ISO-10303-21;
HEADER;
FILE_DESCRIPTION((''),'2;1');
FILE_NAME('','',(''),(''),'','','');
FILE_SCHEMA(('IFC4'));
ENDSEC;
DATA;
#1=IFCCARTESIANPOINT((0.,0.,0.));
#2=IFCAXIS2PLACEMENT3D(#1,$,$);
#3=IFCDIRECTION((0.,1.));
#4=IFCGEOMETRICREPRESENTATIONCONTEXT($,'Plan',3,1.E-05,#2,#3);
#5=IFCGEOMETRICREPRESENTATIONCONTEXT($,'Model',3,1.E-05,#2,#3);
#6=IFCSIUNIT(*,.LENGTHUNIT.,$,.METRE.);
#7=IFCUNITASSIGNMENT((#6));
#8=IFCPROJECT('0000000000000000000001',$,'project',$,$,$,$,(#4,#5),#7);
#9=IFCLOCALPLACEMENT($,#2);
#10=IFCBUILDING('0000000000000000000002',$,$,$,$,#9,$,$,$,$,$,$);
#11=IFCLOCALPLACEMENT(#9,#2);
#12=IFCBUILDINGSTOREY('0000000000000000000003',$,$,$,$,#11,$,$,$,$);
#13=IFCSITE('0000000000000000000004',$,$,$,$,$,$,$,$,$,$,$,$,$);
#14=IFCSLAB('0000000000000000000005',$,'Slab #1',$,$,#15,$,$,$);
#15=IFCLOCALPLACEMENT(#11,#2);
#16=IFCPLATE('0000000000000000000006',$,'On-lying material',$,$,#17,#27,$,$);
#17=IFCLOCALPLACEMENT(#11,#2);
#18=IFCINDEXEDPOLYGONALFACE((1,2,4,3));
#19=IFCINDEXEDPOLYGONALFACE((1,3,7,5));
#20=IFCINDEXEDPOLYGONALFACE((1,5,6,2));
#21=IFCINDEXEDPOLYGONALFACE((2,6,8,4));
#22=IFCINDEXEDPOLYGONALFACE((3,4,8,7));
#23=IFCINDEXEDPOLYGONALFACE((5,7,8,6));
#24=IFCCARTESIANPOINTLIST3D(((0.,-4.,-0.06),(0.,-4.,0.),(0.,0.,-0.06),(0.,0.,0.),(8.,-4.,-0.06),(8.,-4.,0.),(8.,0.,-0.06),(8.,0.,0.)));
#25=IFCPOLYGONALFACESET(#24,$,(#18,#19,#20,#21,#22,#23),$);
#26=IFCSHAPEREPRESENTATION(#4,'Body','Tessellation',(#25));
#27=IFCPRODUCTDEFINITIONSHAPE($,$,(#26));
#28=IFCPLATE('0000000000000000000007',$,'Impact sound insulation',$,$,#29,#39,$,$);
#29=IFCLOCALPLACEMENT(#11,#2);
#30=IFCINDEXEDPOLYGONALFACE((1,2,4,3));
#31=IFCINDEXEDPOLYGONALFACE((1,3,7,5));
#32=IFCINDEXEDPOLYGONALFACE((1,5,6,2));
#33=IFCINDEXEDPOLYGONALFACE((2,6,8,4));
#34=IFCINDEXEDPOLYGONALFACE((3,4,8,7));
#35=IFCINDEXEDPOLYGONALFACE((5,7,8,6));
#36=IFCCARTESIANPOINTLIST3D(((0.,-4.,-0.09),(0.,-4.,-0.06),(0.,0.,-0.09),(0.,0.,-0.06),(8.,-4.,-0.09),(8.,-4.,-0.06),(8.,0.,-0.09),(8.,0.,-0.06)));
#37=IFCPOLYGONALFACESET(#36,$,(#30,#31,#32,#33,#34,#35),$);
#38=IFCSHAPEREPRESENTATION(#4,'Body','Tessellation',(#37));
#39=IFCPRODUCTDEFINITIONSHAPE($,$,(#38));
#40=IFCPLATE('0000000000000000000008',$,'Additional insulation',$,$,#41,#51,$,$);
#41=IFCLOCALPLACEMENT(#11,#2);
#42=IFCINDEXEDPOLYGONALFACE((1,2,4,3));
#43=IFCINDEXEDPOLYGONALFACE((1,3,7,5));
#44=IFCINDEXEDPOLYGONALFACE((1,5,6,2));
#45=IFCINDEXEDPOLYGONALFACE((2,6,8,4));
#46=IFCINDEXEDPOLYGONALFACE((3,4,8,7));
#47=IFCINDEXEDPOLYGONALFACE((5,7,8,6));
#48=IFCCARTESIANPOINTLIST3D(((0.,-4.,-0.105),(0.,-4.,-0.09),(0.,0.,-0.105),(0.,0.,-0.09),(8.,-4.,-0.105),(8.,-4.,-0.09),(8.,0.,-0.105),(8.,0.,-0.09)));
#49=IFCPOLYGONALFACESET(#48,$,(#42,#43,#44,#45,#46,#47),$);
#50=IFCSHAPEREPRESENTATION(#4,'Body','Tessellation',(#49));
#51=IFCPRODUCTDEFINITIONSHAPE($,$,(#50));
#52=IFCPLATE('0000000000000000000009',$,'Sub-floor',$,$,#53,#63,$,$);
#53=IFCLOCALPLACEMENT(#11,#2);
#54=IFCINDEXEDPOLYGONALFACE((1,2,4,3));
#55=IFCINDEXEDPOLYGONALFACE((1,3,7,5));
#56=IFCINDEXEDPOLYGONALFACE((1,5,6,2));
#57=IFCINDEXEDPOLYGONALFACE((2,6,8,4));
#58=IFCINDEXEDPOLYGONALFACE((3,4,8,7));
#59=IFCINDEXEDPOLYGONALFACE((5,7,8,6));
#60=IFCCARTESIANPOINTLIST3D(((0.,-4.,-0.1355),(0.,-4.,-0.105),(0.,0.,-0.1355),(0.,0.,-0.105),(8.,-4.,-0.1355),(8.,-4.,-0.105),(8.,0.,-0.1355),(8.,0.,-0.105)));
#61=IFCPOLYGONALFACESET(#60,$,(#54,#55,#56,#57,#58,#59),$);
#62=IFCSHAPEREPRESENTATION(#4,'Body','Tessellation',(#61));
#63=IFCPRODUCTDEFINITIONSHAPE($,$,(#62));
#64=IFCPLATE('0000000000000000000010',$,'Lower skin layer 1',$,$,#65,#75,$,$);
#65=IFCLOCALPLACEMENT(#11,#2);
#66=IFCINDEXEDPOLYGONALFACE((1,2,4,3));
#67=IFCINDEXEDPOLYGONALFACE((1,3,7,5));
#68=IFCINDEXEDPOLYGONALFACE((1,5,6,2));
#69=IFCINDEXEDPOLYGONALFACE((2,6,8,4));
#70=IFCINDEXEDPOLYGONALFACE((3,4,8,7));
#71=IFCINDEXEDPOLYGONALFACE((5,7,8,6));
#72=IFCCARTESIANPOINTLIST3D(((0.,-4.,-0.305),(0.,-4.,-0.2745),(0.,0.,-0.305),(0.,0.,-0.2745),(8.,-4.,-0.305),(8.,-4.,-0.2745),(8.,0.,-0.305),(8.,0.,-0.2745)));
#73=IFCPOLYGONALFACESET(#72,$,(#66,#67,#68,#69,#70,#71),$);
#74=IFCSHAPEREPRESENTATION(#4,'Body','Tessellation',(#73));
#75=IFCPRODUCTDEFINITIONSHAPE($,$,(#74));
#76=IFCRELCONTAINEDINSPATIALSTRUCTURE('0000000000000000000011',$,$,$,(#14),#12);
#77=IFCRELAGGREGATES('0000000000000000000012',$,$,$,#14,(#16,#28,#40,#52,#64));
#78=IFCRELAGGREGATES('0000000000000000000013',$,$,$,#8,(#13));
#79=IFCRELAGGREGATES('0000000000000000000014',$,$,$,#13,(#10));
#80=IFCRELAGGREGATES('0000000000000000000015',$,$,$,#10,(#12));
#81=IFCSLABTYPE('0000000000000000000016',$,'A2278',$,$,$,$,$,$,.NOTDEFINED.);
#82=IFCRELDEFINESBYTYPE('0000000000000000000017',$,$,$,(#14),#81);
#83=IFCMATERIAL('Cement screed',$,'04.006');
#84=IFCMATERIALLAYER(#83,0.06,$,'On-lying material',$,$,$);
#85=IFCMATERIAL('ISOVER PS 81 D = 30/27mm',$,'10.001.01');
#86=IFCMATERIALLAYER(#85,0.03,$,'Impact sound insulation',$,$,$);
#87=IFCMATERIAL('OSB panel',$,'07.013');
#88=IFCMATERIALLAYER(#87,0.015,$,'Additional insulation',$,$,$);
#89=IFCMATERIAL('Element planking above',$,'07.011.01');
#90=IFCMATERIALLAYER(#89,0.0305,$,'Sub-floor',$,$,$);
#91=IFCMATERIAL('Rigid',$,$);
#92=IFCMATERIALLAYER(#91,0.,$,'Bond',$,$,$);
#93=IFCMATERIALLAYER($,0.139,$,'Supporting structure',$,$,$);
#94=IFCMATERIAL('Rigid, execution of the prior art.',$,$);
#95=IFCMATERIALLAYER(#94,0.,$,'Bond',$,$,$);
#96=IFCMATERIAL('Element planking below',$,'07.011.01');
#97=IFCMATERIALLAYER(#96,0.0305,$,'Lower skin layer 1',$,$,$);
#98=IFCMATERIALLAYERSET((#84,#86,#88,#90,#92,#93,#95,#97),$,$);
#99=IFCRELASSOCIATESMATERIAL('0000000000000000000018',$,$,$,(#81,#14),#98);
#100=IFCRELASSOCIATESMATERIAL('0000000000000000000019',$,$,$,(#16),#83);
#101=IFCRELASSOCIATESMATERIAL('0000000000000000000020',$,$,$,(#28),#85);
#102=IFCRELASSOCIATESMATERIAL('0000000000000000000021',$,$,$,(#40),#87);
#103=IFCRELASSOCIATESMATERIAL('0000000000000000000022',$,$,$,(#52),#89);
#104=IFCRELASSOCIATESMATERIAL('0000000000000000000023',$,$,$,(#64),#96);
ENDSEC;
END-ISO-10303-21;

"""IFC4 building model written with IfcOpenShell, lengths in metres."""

from ifc_helpers import new_model, si_unit, direction, frame, frame_2d, origin, origin_with_axes, place, context, project, spatial, rectangle, extrude, material, layer, layer_set, type_object, element, aggregate, save


model = new_model("IFC4")

# Units and contexts
plan_context = context("Plan", 3, precision=1e-05, world=origin(), true_north=direction((0.0, 1.0)))
model_context = context("Model", 3, precision=1e-05, world=origin(), true_north=direction((0.0, 1.0)))
ifc_project = project(units=[si_unit("LENGTHUNIT", "METRE")], contexts=[plan_context, model_context])

# Site, building, storey
site = spatial("IfcSite", under=ifc_project)
building_placement = place(None, origin())
building = spatial("IfcBuilding", under=site, at=building_placement)
storey_placement = place(building_placement, origin())
storey = spatial("IfcBuildingStorey", under=building, at=storey_placement)

# Slab, plates
ifc_material_1 = material(Name="Cement screed", Category="04.006")
ifc_layer_1 = layer(ifc_material_1, 0.06, Name="On-lying material")
ifc_material_2 = material(Name="ISOVER PS 81 D = 30/27mm", Category="10.001.01")
ifc_layer_2 = layer(ifc_material_2, 0.03, Name="Impact sound insulation")
ifc_material_3 = material(Name="OSB panel", Category="07.013")
ifc_layer_3 = layer(ifc_material_3, 0.015, Name="Additional insulation")
ifc_material_4 = material(Name="Element planking above", Category="07.011.01")
ifc_layer_4 = layer(ifc_material_4, 0.0305, Name="Sub-floor")
ifc_material_5 = material(Name="Rigid")
ifc_layer_5 = layer(ifc_material_5, 0.0, Name="Bond")
ifc_layer_6 = layer(None, 0.139, Name="Supporting structure")
ifc_material_6 = material(Name="Rigid, execution of the prior art.")
ifc_layer_7 = layer(ifc_material_6, 0.0, Name="Bond")
ifc_material_7 = material(Name="Element planking below", Category="07.011.01")
ifc_layer_8 = layer(ifc_material_7, 0.0305, Name="Lower skin layer 1")
ifc_layer_set = layer_set([ifc_layer_1, ifc_layer_2, ifc_layer_3, ifc_layer_4, ifc_layer_5, ifc_layer_6, ifc_layer_7, ifc_layer_8])
slab_type = type_object("IfcSlabType", Name="A2278", PredefinedType="NOTDEFINED", material=ifc_layer_set)
slab_placement = place(None, frame((0.0, 0.0, 0.0), z_axis=(0.0, 0.0, -1.0), x_axis=(1.0, 0.0, 0.0)))
slab = element("IfcSlab", 1, at=slab_placement, inside=storey, type_object=slab_type, material=ifc_layer_set, Name="Slab #1")
plate_1_placement = place(slab_placement, origin())
plate_1 = element("IfcPlate", 2, at=plate_1_placement, material=ifc_material_1, Name="On-lying material", context=plan_context, shape_type="SweptSolid", body=[
    extrude(rectangle(XDim=8.0, YDim=4.0, at=frame_2d((4.0, 2.0), x_axis=(1.0, 0.0))), origin_with_axes(), (0.0, 0.0, 1.0), 0.06),
])
plate_2_placement = place(slab_placement, origin())
plate_2 = element("IfcPlate", 3, at=plate_2_placement, material=ifc_material_2, Name="Impact sound insulation", context=plan_context, shape_type="SweptSolid", body=[
    extrude(rectangle(XDim=8.0, YDim=4.0, at=frame_2d((4.0, 2.0), x_axis=(1.0, 0.0))), frame((0.0, 0.0, 0.06), z_axis=(0.0, 0.0, 1.0), x_axis=(1.0, 0.0, 0.0)), (0.0, 0.0, 1.0), 0.03),
])
plate_3_placement = place(slab_placement, origin())
plate_3 = element("IfcPlate", 4, at=plate_3_placement, material=ifc_material_3, Name="Additional insulation", context=plan_context, shape_type="SweptSolid", body=[
    extrude(rectangle(XDim=8.0, YDim=4.0, at=frame_2d((4.0, 2.0), x_axis=(1.0, 0.0))), frame((0.0, 0.0, 0.09), z_axis=(0.0, 0.0, 1.0), x_axis=(1.0, 0.0, 0.0)), (0.0, 0.0, 1.0), 0.015),
])
plate_4_placement = place(slab_placement, origin())
plate_4 = element("IfcPlate", 5, at=plate_4_placement, material=ifc_material_4, Name="Sub-floor", context=plan_context, shape_type="SweptSolid", body=[
    extrude(rectangle(XDim=8.0, YDim=4.0, at=frame_2d((4.0, 2.0), x_axis=(1.0, 0.0))), frame((0.0, 0.0, 0.105), z_axis=(0.0, 0.0, 1.0), x_axis=(1.0, 0.0, 0.0)), (0.0, 0.0, 1.0), 0.0305),
])
plate_5_placement = place(slab_placement, origin())
plate_5 = element("IfcPlate", 6, at=plate_5_placement, material=ifc_material_7, Name="Lower skin layer 1", context=plan_context, shape_type="SweptSolid", body=[
    extrude(rectangle(XDim=8.0, YDim=4.0, at=frame_2d((4.0, 2.0), x_axis=(1.0, 0.0))), frame((0.0, 0.0, 0.2745), z_axis=(0.0, 0.0, 1.0), x_axis=(1.0, 0.0, 0.0)), (0.0, 0.0, 1.0), 0.0305),
])
aggregate(slab, [plate_1, plate_2, plate_3, plate_4, plate_5])

save(model, "model.ifc")
